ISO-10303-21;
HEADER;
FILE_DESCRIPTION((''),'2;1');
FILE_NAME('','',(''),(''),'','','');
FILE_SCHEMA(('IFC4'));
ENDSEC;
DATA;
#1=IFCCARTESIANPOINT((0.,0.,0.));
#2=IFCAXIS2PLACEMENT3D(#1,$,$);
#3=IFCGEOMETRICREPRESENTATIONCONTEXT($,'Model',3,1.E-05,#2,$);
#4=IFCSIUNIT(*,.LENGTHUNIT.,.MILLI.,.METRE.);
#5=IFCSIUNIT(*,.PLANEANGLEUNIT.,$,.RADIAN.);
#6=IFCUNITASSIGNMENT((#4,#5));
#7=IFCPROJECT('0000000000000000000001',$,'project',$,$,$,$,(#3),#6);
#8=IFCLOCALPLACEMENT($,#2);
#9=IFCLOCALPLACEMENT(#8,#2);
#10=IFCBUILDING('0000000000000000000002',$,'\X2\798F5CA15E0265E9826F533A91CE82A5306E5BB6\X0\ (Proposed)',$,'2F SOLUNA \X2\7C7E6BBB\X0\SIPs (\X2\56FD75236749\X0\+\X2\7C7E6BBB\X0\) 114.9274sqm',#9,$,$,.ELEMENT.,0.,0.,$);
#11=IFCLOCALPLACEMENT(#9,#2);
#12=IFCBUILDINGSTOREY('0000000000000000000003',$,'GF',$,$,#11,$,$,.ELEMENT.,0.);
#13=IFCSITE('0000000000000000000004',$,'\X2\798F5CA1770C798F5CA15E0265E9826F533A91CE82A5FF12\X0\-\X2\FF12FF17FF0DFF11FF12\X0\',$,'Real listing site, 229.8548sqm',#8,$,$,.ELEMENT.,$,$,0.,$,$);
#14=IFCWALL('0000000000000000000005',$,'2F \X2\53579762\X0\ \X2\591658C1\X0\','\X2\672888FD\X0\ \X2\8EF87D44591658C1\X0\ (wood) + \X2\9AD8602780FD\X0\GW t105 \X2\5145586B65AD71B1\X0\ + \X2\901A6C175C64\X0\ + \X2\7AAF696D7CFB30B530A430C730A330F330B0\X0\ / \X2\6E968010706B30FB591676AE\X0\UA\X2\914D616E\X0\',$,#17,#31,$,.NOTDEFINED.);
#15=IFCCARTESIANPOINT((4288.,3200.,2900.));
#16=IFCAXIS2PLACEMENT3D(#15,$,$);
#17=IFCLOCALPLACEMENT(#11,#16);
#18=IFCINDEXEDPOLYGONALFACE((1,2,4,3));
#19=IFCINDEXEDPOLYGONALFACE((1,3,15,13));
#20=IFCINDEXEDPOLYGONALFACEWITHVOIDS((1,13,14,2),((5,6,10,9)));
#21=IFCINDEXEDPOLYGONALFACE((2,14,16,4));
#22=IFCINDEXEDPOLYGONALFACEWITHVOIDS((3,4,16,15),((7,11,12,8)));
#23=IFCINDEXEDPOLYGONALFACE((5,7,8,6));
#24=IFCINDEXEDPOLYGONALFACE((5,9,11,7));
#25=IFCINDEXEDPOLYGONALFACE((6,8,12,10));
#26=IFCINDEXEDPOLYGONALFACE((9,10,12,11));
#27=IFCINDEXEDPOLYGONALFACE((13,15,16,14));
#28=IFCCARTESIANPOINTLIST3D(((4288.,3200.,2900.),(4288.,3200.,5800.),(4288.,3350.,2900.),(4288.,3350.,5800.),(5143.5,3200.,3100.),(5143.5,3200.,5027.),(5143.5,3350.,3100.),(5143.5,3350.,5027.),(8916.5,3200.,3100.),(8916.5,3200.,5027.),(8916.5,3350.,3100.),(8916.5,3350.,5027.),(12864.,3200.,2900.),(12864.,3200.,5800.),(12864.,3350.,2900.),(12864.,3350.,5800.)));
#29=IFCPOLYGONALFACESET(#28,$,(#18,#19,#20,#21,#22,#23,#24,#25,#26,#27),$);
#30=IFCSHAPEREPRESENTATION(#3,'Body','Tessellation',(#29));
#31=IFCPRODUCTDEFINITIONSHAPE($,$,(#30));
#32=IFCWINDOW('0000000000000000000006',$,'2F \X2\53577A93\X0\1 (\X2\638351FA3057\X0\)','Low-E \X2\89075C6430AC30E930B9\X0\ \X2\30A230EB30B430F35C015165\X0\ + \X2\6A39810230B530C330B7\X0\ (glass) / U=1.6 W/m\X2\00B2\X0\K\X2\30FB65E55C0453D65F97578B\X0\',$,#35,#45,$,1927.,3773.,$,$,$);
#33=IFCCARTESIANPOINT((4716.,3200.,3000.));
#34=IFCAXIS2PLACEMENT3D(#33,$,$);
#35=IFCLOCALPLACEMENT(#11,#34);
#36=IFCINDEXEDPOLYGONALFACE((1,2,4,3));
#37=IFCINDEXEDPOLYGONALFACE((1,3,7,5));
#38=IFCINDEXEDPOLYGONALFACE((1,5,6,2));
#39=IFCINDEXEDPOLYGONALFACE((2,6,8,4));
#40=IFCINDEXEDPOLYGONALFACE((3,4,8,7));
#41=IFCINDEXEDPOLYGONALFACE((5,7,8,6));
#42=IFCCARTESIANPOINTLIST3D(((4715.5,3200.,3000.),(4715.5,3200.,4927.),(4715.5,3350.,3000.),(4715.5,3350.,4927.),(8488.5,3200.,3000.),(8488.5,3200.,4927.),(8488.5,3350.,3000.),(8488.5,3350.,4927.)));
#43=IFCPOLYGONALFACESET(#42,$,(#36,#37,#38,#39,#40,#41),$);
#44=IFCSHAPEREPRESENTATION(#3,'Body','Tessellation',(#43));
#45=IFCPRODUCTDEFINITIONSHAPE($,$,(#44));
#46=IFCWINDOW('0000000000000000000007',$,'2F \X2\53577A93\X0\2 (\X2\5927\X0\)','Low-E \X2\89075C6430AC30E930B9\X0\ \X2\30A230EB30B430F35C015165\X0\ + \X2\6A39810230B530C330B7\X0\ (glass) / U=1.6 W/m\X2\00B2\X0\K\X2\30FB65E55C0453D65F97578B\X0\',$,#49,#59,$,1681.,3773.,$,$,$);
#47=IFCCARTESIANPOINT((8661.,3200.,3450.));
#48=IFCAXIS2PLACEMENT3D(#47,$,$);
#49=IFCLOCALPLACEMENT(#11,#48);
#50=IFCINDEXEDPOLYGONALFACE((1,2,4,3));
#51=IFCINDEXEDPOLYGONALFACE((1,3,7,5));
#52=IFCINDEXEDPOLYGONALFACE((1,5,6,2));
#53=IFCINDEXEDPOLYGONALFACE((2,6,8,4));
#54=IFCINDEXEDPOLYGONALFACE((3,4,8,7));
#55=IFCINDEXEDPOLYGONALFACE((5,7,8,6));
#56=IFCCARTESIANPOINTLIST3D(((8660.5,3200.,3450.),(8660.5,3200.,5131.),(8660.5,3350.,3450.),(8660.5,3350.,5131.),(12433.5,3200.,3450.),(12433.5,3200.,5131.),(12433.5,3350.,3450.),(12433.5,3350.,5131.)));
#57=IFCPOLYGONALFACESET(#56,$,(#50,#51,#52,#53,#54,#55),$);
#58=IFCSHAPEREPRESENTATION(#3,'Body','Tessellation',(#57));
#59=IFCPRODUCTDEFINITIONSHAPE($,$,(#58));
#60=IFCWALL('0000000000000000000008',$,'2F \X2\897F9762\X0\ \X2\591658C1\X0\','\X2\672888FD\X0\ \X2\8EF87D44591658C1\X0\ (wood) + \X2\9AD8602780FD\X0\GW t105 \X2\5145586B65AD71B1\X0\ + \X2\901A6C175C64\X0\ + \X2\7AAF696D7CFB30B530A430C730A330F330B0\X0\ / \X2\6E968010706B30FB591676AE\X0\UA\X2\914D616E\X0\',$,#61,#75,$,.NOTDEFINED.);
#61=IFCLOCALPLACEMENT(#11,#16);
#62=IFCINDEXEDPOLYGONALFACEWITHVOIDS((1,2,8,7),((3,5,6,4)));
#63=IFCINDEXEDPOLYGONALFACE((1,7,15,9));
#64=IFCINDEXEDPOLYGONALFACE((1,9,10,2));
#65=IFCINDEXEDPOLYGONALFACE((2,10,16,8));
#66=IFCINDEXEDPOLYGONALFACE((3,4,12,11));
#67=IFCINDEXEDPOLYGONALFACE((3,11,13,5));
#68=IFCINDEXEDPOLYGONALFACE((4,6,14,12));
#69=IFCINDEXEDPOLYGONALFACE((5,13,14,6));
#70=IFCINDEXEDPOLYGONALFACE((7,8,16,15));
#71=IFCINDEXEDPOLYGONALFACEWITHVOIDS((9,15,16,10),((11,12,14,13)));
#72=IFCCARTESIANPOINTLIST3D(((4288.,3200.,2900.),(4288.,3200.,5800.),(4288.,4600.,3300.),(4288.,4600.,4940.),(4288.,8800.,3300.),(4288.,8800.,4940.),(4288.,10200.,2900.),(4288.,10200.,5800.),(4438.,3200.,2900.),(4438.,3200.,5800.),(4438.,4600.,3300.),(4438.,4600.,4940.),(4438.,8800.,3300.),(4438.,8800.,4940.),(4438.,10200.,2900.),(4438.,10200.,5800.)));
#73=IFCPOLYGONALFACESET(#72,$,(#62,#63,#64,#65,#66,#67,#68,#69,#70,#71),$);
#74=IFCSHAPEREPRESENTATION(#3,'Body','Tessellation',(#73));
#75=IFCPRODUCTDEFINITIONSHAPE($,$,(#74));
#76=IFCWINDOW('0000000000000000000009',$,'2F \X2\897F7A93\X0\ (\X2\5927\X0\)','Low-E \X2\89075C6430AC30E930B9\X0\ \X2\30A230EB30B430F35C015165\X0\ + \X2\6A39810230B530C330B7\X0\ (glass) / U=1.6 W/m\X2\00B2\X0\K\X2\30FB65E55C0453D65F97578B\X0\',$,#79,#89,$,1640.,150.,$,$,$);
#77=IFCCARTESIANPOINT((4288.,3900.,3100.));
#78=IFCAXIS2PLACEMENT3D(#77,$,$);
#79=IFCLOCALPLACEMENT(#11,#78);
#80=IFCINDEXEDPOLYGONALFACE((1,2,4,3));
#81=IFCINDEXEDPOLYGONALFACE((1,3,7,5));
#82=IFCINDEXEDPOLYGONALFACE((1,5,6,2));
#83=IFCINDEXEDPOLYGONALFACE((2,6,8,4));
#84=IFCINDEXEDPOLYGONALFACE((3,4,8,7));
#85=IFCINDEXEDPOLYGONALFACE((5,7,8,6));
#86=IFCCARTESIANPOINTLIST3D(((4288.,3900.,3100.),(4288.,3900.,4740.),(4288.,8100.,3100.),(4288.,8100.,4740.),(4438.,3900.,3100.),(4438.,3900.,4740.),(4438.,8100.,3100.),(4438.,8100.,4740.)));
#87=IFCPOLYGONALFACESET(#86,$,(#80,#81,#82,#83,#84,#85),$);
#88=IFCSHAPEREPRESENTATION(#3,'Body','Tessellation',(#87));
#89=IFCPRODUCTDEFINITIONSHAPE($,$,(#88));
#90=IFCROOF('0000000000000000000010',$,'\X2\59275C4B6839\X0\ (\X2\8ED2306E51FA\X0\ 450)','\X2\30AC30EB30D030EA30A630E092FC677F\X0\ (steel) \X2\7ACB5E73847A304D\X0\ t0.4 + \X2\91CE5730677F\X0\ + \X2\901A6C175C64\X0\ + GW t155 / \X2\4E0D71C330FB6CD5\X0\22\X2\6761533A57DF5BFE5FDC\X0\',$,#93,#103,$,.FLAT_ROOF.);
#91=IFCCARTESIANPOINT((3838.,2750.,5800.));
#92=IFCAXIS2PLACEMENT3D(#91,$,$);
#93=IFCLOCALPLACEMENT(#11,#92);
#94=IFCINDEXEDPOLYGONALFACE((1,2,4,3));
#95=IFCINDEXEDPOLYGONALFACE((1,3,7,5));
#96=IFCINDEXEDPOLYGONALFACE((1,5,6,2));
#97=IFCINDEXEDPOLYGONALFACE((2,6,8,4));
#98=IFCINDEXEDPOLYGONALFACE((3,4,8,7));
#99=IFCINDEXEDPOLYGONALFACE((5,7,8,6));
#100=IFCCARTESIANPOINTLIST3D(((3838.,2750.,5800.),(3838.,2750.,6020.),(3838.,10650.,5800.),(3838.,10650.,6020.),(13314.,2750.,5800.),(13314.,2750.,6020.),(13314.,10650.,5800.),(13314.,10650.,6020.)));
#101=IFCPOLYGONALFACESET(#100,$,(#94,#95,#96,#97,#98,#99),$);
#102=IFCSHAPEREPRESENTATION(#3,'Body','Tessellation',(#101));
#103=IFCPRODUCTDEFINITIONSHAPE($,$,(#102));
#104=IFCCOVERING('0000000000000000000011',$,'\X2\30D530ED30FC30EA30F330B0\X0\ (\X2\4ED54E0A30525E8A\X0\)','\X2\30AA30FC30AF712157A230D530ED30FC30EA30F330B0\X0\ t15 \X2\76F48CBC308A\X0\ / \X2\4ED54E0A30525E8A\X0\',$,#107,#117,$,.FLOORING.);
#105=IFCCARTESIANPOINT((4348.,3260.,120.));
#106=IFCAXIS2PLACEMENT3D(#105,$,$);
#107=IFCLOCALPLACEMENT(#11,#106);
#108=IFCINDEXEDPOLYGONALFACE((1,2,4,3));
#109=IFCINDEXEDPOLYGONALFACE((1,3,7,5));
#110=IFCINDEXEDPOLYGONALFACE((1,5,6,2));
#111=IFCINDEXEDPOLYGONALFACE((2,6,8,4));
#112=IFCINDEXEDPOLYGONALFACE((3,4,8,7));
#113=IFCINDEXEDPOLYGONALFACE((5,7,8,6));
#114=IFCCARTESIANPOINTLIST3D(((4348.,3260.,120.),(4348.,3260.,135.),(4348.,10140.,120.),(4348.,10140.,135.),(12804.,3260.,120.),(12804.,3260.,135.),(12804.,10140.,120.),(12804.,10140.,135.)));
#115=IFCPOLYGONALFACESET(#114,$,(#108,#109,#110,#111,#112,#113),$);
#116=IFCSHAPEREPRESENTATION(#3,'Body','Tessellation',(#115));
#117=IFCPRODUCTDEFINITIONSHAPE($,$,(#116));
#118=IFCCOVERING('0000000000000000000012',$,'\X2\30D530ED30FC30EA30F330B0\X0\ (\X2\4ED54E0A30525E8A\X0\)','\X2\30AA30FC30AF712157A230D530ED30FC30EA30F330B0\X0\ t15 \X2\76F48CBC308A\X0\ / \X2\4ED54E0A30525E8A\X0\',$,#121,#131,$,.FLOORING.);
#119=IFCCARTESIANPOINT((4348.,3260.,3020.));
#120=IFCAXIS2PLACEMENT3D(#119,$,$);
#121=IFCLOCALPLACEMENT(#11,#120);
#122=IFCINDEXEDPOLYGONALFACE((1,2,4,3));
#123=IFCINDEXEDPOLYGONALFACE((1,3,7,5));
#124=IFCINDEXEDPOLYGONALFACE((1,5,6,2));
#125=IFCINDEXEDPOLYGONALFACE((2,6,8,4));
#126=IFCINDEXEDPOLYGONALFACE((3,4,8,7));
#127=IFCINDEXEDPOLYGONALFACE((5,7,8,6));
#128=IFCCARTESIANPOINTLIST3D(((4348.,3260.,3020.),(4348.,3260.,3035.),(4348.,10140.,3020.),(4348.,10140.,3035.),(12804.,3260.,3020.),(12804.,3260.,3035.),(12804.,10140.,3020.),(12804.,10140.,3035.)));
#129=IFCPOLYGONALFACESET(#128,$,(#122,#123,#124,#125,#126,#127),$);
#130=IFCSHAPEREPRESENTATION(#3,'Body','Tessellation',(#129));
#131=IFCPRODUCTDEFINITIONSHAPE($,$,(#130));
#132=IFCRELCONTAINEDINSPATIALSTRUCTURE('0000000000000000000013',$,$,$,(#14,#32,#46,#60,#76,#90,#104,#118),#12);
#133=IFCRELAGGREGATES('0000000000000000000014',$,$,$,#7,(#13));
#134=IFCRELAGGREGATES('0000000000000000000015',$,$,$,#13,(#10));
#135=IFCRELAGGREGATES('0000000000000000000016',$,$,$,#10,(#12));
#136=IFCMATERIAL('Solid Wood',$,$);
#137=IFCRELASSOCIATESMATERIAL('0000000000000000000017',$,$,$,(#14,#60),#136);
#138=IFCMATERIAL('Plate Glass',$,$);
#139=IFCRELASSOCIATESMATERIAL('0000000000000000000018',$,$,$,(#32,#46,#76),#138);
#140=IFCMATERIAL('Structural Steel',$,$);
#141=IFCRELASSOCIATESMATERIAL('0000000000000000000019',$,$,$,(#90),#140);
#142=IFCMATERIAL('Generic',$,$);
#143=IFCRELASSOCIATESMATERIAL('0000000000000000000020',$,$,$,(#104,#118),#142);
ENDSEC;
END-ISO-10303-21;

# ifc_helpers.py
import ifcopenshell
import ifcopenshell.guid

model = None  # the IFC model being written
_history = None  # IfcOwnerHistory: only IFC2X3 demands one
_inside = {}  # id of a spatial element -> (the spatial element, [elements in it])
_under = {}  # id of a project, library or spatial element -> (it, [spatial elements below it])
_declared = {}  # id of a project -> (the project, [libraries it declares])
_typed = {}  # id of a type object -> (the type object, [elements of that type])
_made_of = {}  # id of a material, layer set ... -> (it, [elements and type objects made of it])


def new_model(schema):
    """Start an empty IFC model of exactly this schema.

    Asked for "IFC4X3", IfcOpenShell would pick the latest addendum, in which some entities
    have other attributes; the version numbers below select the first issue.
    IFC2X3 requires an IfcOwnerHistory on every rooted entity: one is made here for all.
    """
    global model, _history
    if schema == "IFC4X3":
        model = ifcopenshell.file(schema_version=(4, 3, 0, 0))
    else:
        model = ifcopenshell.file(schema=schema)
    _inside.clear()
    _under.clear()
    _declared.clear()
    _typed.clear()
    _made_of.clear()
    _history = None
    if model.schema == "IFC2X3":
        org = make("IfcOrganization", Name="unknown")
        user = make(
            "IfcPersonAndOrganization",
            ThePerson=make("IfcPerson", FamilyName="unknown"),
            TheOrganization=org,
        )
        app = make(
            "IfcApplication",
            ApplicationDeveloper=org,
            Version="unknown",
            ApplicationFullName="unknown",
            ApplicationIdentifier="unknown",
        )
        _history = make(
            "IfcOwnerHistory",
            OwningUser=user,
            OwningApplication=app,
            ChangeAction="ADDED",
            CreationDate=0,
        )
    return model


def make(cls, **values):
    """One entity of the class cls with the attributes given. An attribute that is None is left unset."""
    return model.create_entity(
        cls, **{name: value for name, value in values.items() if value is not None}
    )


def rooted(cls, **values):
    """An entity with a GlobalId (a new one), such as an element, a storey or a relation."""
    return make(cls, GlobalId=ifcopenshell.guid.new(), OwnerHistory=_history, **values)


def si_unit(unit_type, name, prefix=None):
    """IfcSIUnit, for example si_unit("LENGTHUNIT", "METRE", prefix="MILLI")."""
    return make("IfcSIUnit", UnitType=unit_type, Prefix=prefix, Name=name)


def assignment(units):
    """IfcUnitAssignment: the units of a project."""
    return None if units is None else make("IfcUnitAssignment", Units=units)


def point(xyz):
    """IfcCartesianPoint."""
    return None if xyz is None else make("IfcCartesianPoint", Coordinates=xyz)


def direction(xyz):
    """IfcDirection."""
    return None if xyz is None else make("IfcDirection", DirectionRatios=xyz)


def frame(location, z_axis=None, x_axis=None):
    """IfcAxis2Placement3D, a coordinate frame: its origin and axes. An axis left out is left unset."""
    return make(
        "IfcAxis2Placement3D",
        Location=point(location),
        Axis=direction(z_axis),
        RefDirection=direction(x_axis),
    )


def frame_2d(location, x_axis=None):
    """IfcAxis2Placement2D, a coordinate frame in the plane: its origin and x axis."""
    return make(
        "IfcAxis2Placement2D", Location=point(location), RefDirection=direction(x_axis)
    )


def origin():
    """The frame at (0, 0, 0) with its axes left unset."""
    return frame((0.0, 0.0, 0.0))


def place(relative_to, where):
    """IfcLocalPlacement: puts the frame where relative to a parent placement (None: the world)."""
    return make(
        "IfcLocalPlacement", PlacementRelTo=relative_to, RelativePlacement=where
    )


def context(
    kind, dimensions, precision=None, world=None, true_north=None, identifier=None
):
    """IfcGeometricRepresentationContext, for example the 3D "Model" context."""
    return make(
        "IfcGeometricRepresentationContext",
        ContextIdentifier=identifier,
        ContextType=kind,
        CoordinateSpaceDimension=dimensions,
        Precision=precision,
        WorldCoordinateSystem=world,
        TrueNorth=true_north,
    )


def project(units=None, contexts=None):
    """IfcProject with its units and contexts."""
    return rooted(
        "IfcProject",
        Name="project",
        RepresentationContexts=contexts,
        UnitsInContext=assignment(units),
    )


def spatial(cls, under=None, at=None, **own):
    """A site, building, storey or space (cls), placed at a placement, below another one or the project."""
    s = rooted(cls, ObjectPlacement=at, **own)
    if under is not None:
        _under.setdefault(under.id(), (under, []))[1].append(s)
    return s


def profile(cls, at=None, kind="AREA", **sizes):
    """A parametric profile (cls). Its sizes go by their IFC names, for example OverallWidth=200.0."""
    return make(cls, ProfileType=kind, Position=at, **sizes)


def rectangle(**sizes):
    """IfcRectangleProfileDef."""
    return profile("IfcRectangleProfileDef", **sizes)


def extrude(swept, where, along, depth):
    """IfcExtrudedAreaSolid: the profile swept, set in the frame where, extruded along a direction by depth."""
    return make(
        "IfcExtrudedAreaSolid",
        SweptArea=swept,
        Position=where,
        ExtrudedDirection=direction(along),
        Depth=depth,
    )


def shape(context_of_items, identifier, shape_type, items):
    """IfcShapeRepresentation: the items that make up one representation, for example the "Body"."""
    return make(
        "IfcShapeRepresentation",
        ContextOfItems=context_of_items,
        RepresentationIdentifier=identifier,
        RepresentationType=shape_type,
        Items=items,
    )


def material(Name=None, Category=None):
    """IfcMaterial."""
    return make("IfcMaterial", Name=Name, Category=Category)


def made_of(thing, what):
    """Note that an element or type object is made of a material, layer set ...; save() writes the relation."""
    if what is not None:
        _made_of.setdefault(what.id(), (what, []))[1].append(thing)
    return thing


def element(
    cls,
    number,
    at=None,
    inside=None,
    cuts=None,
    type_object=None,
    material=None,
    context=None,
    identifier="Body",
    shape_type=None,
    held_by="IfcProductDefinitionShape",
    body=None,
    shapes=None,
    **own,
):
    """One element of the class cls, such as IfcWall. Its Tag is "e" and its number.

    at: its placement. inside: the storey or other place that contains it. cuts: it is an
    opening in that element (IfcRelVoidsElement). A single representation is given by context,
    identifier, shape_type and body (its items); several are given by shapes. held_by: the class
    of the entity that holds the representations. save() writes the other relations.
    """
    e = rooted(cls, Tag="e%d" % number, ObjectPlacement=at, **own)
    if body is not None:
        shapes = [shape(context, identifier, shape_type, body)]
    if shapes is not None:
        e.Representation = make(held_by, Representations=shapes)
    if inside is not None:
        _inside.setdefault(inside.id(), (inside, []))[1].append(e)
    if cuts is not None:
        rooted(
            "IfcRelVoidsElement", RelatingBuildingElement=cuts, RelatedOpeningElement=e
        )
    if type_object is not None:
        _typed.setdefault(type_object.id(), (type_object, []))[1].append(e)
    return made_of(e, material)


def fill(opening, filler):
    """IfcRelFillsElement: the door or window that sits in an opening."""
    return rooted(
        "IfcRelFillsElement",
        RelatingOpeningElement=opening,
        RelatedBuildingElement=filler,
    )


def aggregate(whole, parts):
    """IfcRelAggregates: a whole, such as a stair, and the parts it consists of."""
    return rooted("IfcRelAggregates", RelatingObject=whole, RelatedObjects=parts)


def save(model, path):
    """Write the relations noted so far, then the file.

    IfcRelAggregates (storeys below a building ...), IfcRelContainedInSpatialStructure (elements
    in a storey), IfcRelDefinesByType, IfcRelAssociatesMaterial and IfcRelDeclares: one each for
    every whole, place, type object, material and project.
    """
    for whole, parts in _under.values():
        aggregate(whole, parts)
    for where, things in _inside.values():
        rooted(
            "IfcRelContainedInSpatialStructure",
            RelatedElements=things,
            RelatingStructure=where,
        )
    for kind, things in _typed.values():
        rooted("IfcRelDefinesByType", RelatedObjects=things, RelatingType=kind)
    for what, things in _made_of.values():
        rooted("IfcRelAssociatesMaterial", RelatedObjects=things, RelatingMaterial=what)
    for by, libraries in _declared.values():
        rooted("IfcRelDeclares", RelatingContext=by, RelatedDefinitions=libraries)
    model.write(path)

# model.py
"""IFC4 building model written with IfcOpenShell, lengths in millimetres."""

from ifc_helpers import new_model, si_unit, frame, frame_2d, origin, place, context, project, spatial, rectangle, extrude, material, element, fill, save


model = new_model("IFC4")

# Units and contexts
model_context = context("Model", 3, precision=1e-05, world=origin())
ifc_project = project(units=[si_unit("LENGTHUNIT", "METRE", prefix="MILLI"), si_unit("PLANEANGLEUNIT", "RADIAN")], contexts=[model_context])

# Site, building, storey
site_placement = place(None, origin())
site = spatial("IfcSite", under=ifc_project, at=site_placement, Name="福岡県福岡市早良区野芥２-２７－１２", ObjectType="Real listing site, 229.8548sqm", CompositionType="ELEMENT", RefElevation=0.0)
building_placement = place(site_placement, origin())
building = spatial("IfcBuilding", under=site, at=building_placement, Name="福岡市早良区野芥の家 (Proposed)", ObjectType="2F SOLUNA 籾殻SIPs (国産杉+籾殻) 114.9274sqm", CompositionType="ELEMENT", ElevationOfRefHeight=0.0, ElevationOfTerrain=0.0)
storey_placement = place(building_placement, origin())
storey = spatial("IfcBuildingStorey", under=building, at=storey_placement, Name="GF", CompositionType="ELEMENT", Elevation=0.0)

# Shared definitions
ifc_material_1 = material(Name="Solid Wood")

# Shared definitions
ifc_material_2 = material(Name="Plate Glass")

# Wall, openings, windows
wall_1_placement = place(storey_placement, frame((4288.0, 3200.0, 2900.0)))
wall_1 = element("IfcWall", 1, at=wall_1_placement, inside=storey, material=ifc_material_1, Name="2F 南面 外壁", Description="木製 軸組外壁 (wood) + 高性能GW t105 充填断熱 + 通気層 + 窯業系サイディング / 準耐火・外皮UA配慮", PredefinedType="NOTDEFINED", context=model_context, shape_type="SweptSolid", body=[
    extrude(rectangle(XDim=8576.0, YDim=150.0, at=frame_2d((4288.0, 75.0))), frame((4288.0, 3200.0, 2900.0)), (0.0, 0.0, 1.0), 2900.0),
])
opening_1_placement = place(storey_placement, frame((4716.0, 3200.0, 3000.0)))
opening_1 = element("IfcOpeningElement", 2, at=opening_1_placement, cuts=wall_1, PredefinedType="NOTDEFINED", context=model_context, shape_type="SweptSolid", body=[
    extrude(rectangle(XDim=3773.0, YDim=150.0, at=frame_2d((1886.0, 75.0))), frame((4716.0, 3200.0, 3000.0)), (0.0, 0.0, 1.0), 1927.0),
])
opening_2_placement = place(storey_placement, frame((8661.0, 3200.0, 3450.0)))
opening_2 = element("IfcOpeningElement", 3, at=opening_2_placement, cuts=wall_1, PredefinedType="NOTDEFINED", context=model_context, shape_type="SweptSolid", body=[
    extrude(rectangle(XDim=3773.0, YDim=150.0, at=frame_2d((1886.0, 75.0))), frame((8661.0, 3200.0, 3450.0)), (0.0, 0.0, 1.0), 1681.0),
])
window_1_placement = place(storey_placement, frame((4716.0, 3200.0, 3000.0)))
window_1 = element("IfcWindow", 4, at=window_1_placement, inside=storey, material=ifc_material_2, Name="2F 南窓1 (掃出し)", Description="Low-E 複層ガラス アルゴン封入 + 樹脂サッシ (glass) / U=1.6 W/m²K・日射取得型", OverallHeight=1927.0, OverallWidth=3773.0, context=model_context, shape_type="SweptSolid", body=[
    extrude(rectangle(XDim=3773.0, YDim=150.0, at=frame_2d((1886.0, 75.0))), frame((4716.0, 3200.0, 3000.0)), (0.0, 0.0, 1.0), 1927.0),
])
fill(opening_1, window_1)
window_2_placement = place(storey_placement, frame((8661.0, 3200.0, 3450.0)))
window_2 = element("IfcWindow", 5, at=window_2_placement, inside=storey, material=ifc_material_2, Name="2F 南窓2 (大)", Description="Low-E 複層ガラス アルゴン封入 + 樹脂サッシ (glass) / U=1.6 W/m²K・日射取得型", OverallHeight=1681.0, OverallWidth=3773.0, context=model_context, shape_type="SweptSolid", body=[
    extrude(rectangle(XDim=3773.0, YDim=150.0, at=frame_2d((1886.0, 75.0))), frame((8661.0, 3200.0, 3450.0)), (0.0, 0.0, 1.0), 1681.0),
])
fill(opening_2, window_2)

# Wall, opening, window
wall_2_placement = place(storey_placement, frame((4288.0, 3200.0, 2900.0)))
wall_2 = element("IfcWall", 6, at=wall_2_placement, inside=storey, material=ifc_material_1, Name="2F 西面 外壁", Description="木製 軸組外壁 (wood) + 高性能GW t105 充填断熱 + 通気層 + 窯業系サイディング / 準耐火・外皮UA配慮", PredefinedType="NOTDEFINED", context=model_context, shape_type="SweptSolid", body=[
    extrude(rectangle(XDim=150.0, YDim=7000.0, at=frame_2d((75.0, 3500.0))), frame((4288.0, 3200.0, 2900.0)), (0.0, 0.0, 1.0), 2900.0),
])
opening_3_placement = place(storey_placement, frame((4288.0, 3900.0, 3100.0)))
opening_3 = element("IfcOpeningElement", 7, at=opening_3_placement, cuts=wall_2, PredefinedType="NOTDEFINED", context=model_context, shape_type="SweptSolid", body=[
    extrude(rectangle(XDim=150.0, YDim=4200.0, at=frame_2d((75.0, 2100.0))), frame((4288.0, 3900.0, 3100.0)), (0.0, 0.0, 1.0), 1640.0),
])
window_3_placement = place(storey_placement, frame((4288.0, 3900.0, 3100.0)))
window_3 = element("IfcWindow", 8, at=window_3_placement, inside=storey, material=ifc_material_2, Name="2F 西窓 (大)", Description="Low-E 複層ガラス アルゴン封入 + 樹脂サッシ (glass) / U=1.6 W/m²K・日射取得型", OverallHeight=1640.0, OverallWidth=150.0, context=model_context, shape_type="SweptSolid", body=[
    extrude(rectangle(XDim=150.0, YDim=4200.0, at=frame_2d((75.0, 2100.0))), frame((4288.0, 3900.0, 3100.0)), (0.0, 0.0, 1.0), 1640.0),
])
fill(opening_3, window_3)

# Roof
ifc_material_3 = material(Name="Structural Steel")
roof_placement = place(storey_placement, frame((3838.0, 2750.0, 5800.0)))
element("IfcRoof", 9, at=roof_placement, inside=storey, material=ifc_material_3, Name="大屋根 (軒の出 450)", Description="ガルバリウム鋼板 (steel) 立平葺き t0.4 + 野地板 + 通気層 + GW t155 / 不燃・法22条区域対応", PredefinedType="FLAT_ROOF", context=model_context, shape_type="SweptSolid", body=[
    extrude(rectangle(XDim=9476.0, YDim=7900.0, at=frame_2d((4738.0, 3950.0))), frame((3838.0, 2750.0, 5800.0)), (0.0, 0.0, 1.0), 220.0),
])

# Coverings
ifc_material_4 = material(Name="Generic")
covering_1_placement = place(storey_placement, frame((4348.0, 3260.0, 120.0)))
element("IfcCovering", 10, at=covering_1_placement, inside=storey, material=ifc_material_4, Name="フローリング (仕上げ床)", Description="オーク無垢フローリング t15 直貼り / 仕上げ床", PredefinedType="FLOORING", context=model_context, shape_type="SweptSolid", body=[
    extrude(rectangle(XDim=8456.0, YDim=6880.0, at=frame_2d((4228.0, 3440.0))), frame((4348.0, 3260.0, 120.0)), (0.0, 0.0, 1.0), 15.0),
])
covering_2_placement = place(storey_placement, frame((4348.0, 3260.0, 3020.0)))
element("IfcCovering", 11, at=covering_2_placement, inside=storey, material=ifc_material_4, Name="フローリング (仕上げ床)", Description="オーク無垢フローリング t15 直貼り / 仕上げ床", PredefinedType="FLOORING", context=model_context, shape_type="SweptSolid", body=[
    extrude(rectangle(XDim=8456.0, YDim=6880.0, at=frame_2d((4228.0, 3440.0))), frame((4348.0, 3260.0, 3020.0)), (0.0, 0.0, 1.0), 15.0),
])

save(model, "model.ifc")
